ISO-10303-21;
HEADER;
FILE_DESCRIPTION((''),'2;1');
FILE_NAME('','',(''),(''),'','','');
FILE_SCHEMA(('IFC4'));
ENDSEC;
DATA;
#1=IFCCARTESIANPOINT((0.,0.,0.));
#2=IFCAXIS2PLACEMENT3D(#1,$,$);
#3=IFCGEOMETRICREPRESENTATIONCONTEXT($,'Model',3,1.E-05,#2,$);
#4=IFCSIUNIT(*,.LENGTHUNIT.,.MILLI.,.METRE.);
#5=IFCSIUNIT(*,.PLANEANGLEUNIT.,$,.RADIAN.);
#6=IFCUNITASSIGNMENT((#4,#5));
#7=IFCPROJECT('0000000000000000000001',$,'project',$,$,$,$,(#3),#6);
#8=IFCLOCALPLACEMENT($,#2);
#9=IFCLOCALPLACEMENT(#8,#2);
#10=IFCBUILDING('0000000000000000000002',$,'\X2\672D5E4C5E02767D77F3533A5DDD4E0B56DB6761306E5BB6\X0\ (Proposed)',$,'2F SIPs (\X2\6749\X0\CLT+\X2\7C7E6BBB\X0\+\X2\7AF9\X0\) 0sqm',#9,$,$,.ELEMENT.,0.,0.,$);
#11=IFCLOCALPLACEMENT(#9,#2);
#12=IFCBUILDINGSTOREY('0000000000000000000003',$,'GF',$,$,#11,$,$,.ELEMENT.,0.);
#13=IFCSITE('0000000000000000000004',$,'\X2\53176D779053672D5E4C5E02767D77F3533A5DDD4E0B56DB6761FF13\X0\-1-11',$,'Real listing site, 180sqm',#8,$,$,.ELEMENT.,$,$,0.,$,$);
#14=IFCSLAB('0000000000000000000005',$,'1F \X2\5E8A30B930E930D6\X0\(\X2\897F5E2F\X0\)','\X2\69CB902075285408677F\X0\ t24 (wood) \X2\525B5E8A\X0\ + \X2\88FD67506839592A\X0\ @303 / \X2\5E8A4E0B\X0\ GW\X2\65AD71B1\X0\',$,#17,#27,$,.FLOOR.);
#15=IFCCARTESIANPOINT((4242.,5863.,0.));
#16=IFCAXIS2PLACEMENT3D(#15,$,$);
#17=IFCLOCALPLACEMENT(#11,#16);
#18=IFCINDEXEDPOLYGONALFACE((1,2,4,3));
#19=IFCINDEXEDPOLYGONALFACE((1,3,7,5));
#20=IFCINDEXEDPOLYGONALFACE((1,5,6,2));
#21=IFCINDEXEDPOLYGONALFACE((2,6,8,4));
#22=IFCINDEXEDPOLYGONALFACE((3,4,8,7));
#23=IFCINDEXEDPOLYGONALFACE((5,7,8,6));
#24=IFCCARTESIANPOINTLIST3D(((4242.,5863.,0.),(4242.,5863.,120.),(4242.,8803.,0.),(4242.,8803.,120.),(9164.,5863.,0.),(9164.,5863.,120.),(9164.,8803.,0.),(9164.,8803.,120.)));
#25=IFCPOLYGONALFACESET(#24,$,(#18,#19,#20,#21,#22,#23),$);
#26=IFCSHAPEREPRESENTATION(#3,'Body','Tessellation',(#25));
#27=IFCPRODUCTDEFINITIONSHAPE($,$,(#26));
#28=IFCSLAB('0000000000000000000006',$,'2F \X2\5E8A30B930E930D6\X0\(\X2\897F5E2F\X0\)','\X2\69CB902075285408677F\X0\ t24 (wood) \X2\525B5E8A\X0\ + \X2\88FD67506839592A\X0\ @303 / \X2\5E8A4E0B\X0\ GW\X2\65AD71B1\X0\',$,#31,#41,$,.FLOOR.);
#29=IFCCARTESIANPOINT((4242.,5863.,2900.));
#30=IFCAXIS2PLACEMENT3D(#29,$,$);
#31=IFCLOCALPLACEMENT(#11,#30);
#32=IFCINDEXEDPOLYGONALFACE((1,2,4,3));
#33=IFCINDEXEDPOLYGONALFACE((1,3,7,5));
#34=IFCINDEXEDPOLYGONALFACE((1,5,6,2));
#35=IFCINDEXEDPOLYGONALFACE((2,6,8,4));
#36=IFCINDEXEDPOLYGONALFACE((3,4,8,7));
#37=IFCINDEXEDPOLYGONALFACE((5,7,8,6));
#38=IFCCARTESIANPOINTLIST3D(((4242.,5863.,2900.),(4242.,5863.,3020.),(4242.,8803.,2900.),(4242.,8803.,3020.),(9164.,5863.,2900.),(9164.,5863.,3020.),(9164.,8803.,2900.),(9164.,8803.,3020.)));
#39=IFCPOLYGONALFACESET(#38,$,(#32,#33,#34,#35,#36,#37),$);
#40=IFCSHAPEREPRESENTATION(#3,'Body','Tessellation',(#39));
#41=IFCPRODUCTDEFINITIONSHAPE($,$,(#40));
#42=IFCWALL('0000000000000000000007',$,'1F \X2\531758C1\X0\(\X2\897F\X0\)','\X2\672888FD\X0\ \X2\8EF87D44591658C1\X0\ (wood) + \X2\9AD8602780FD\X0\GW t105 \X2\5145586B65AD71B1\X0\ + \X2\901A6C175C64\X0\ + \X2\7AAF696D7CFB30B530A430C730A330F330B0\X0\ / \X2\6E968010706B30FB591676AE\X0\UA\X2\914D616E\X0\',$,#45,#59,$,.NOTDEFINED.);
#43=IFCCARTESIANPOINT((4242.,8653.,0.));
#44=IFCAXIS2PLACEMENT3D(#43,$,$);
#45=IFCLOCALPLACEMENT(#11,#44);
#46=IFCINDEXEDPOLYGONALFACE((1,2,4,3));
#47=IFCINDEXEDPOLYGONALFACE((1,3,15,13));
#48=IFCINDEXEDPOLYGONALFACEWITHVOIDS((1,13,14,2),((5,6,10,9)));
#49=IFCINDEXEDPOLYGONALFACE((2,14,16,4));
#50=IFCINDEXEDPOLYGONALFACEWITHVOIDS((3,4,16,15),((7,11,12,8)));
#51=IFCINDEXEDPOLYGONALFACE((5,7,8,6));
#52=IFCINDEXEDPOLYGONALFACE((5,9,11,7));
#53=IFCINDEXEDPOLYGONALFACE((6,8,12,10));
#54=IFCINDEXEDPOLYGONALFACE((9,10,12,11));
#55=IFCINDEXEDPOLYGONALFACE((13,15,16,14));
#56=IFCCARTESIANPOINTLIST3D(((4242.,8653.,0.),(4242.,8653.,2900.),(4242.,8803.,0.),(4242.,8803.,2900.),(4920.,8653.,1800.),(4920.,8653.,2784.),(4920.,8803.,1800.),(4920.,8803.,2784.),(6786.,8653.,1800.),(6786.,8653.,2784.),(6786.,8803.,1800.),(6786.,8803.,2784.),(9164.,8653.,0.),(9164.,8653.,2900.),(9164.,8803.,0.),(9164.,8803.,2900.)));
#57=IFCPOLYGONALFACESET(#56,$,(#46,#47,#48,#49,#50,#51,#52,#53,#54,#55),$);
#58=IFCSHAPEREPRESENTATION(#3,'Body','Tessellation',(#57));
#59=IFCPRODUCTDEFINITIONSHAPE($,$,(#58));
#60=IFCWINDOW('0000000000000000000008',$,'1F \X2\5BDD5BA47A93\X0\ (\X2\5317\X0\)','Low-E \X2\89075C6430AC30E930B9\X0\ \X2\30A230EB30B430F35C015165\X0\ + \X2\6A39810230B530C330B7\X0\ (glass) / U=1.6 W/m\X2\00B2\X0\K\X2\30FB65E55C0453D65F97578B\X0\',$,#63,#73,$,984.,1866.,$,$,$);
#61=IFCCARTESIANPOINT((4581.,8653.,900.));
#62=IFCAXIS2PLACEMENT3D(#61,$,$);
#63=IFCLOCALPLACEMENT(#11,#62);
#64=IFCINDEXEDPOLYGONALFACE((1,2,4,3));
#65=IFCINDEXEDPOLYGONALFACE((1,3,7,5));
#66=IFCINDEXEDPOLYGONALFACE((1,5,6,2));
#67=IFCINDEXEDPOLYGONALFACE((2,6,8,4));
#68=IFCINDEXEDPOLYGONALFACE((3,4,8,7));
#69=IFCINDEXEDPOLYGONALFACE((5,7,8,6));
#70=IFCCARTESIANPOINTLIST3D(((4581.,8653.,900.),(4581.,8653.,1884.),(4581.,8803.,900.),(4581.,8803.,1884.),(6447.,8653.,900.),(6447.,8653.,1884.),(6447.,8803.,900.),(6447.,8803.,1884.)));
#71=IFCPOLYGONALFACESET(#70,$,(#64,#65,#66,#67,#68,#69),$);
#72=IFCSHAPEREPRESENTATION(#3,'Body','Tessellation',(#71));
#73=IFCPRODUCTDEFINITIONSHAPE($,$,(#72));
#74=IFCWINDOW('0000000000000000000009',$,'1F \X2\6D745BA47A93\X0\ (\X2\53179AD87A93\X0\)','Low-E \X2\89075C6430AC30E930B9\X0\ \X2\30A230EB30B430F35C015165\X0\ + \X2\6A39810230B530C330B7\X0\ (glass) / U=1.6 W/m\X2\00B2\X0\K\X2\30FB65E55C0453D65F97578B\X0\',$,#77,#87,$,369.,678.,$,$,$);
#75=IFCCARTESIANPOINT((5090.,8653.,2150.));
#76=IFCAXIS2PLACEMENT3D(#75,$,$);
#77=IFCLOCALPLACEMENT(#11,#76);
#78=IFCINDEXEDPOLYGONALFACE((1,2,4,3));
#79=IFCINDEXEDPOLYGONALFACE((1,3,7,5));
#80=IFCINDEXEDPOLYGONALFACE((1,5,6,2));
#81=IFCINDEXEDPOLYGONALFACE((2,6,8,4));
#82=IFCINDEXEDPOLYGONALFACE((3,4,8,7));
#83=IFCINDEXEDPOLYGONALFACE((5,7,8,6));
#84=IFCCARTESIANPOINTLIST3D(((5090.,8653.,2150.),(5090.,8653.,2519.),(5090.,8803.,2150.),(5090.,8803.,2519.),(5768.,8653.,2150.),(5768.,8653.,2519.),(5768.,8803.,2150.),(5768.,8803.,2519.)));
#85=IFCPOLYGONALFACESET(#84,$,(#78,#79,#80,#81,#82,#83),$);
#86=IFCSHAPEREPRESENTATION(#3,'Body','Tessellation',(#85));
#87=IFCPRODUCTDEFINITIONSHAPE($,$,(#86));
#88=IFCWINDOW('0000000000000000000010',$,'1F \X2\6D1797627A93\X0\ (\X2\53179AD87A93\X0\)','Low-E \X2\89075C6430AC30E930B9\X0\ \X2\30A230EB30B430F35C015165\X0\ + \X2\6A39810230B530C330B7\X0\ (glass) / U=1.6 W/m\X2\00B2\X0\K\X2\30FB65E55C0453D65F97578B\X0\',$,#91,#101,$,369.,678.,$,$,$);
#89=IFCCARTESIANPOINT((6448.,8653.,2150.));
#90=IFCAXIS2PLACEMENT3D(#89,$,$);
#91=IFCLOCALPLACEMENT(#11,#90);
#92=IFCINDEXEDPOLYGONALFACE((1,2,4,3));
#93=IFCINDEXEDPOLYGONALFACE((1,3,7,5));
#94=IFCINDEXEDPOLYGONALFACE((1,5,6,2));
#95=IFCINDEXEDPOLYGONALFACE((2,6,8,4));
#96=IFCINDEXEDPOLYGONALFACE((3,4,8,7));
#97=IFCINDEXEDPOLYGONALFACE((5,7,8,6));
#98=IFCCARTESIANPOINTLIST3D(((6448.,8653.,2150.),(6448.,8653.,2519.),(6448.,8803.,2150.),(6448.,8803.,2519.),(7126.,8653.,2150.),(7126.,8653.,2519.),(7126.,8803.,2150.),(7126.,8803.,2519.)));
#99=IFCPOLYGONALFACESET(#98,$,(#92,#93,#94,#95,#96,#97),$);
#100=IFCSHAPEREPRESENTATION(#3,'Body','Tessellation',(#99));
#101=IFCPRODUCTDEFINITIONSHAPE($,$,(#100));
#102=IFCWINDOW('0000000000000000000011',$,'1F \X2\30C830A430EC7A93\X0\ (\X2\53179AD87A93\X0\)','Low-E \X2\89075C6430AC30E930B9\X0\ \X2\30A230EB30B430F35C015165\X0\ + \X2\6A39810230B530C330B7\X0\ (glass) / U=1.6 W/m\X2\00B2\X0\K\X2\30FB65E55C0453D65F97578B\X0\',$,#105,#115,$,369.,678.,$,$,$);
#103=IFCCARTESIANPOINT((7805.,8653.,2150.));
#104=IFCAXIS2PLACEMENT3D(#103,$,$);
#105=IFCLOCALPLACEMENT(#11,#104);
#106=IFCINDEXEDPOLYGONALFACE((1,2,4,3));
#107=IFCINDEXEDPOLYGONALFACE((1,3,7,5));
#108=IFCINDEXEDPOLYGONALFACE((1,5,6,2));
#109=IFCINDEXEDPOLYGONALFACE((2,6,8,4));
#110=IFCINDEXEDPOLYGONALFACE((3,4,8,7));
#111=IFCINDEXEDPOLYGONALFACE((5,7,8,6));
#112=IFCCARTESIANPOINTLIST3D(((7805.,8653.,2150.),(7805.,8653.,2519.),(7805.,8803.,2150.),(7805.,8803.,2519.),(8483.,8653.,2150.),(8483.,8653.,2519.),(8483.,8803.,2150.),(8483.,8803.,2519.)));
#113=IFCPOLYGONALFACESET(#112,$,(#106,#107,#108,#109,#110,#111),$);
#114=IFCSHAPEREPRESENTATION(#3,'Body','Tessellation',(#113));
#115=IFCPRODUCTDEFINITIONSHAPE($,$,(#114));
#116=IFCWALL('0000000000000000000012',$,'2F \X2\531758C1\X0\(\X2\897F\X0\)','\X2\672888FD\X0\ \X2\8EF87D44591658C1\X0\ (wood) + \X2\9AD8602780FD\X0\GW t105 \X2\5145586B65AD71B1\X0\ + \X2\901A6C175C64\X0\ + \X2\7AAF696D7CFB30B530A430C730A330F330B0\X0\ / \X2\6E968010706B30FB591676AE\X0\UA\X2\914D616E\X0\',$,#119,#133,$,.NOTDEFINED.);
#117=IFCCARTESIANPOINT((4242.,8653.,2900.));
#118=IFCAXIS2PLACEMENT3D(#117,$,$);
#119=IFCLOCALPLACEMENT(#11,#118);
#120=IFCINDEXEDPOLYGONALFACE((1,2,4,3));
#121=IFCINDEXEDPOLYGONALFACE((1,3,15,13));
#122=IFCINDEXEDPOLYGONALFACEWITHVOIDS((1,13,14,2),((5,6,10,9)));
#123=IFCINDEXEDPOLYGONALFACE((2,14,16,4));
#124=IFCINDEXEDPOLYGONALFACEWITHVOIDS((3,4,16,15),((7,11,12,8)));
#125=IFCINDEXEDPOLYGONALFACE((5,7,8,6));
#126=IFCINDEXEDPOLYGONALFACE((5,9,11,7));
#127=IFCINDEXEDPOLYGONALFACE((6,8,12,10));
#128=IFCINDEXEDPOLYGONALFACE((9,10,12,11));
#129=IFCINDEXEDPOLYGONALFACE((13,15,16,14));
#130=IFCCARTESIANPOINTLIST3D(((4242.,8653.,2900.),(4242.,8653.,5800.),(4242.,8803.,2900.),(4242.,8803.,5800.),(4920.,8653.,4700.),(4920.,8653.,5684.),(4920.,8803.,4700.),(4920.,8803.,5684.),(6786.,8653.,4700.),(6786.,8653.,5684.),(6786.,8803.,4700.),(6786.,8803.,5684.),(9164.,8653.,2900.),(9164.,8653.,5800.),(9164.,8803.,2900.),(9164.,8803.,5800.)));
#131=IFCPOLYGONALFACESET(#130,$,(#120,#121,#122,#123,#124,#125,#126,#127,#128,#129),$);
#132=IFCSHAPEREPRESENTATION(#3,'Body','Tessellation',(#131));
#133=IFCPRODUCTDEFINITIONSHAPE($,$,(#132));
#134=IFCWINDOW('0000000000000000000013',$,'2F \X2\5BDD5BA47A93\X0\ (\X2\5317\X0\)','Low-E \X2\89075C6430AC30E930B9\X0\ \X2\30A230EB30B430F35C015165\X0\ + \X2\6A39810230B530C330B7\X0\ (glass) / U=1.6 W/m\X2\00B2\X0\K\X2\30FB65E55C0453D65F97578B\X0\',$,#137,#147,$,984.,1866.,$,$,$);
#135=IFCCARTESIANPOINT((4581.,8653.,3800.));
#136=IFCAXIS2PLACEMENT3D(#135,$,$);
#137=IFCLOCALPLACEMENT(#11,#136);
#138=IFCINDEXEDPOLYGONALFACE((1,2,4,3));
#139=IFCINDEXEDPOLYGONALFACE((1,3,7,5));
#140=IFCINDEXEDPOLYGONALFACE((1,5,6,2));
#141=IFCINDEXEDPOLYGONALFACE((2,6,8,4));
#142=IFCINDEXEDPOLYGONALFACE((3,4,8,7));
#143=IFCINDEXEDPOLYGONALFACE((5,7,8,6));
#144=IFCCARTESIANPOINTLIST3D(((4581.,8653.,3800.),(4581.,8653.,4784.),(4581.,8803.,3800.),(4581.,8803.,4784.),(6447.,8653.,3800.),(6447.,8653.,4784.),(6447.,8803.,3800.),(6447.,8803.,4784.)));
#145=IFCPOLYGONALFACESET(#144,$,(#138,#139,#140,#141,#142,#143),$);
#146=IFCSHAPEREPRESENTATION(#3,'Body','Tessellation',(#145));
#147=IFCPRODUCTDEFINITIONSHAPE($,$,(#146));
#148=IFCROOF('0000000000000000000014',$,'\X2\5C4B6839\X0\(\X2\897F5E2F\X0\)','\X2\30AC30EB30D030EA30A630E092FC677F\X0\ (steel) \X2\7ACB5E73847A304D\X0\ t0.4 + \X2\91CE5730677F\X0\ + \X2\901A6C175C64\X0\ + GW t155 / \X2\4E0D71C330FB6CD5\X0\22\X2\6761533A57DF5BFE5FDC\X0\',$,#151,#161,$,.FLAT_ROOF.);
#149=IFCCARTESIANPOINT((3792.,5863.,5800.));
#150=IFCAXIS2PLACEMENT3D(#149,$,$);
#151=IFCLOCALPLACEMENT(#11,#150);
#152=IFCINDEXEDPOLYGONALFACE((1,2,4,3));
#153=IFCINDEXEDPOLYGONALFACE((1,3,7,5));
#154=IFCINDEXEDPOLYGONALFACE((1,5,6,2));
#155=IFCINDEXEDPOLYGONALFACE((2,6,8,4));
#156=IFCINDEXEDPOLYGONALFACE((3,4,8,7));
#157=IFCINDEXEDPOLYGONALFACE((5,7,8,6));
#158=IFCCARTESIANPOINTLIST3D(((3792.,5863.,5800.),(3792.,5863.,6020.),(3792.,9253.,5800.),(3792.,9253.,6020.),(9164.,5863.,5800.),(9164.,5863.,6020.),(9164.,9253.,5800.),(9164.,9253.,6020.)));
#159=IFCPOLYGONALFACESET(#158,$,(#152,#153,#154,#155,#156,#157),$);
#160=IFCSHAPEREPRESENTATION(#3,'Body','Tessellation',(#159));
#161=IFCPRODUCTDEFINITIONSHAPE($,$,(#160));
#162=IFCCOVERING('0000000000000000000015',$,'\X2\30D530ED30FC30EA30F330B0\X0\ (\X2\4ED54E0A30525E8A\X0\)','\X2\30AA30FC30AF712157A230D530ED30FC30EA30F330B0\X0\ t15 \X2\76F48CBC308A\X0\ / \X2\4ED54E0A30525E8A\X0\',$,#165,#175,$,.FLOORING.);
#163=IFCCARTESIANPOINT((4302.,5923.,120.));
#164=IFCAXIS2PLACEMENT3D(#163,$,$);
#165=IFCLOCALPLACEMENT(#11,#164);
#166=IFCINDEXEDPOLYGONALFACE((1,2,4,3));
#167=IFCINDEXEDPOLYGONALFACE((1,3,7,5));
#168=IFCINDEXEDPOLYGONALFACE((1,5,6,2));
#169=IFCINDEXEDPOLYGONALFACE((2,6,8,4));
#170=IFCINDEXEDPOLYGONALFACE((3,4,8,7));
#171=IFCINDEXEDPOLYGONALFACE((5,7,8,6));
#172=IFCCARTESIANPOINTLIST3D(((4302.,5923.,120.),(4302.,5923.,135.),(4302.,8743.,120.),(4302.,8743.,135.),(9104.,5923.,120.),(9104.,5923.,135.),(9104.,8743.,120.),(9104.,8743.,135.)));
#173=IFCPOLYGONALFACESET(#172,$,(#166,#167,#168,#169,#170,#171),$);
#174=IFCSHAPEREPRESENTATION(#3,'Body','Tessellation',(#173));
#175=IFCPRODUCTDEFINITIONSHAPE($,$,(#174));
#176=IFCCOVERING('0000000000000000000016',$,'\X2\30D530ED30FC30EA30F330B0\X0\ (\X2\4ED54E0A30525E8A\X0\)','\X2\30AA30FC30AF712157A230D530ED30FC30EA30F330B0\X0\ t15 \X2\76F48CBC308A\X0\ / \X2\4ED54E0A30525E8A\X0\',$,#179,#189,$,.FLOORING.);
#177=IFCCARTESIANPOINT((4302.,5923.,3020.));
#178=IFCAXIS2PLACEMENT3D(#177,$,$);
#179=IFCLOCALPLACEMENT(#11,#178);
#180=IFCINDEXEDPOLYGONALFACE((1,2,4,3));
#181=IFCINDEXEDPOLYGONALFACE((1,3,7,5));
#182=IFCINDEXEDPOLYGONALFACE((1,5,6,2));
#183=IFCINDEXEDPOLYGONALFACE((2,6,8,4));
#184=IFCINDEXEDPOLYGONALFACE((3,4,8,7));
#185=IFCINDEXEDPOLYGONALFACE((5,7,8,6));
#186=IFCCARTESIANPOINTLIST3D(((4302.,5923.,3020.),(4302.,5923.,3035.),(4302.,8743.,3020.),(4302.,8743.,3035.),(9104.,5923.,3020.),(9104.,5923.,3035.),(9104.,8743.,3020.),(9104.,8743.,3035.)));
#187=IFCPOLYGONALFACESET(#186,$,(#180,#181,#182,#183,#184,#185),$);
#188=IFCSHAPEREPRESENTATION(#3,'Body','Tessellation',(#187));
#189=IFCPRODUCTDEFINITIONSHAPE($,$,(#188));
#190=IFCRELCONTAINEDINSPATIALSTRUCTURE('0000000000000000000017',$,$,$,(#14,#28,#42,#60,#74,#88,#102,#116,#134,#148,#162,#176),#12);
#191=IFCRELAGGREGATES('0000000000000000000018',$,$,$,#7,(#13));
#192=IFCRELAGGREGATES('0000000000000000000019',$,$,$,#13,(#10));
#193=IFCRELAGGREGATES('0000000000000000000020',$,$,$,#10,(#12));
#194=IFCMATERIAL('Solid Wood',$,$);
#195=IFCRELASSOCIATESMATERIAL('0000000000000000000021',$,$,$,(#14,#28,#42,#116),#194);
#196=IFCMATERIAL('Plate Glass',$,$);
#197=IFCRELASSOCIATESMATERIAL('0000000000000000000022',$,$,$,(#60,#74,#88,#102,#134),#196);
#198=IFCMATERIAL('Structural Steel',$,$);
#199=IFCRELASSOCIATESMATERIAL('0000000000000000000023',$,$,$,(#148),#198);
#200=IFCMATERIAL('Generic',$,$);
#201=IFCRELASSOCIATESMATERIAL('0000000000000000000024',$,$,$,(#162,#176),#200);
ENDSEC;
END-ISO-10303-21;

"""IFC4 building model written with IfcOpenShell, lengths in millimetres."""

from ifc_helpers import new_model, si_unit, frame, frame_2d, origin, place, context, project, spatial, rectangle, extrude, material, element, fill, save


model = new_model("IFC4")

# Units and contexts
model_context = context("Model", 3, precision=1e-05, world=origin())
ifc_project = project(units=[si_unit("LENGTHUNIT", "METRE", prefix="MILLI"), si_unit("PLANEANGLEUNIT", "RADIAN")], contexts=[model_context])

# Site, building, storey
site_placement = place(None, origin())
site = spatial("IfcSite", under=ifc_project, at=site_placement, Name="北海道札幌市白石区川下四条３-1-11", ObjectType="Real listing site, 180sqm", CompositionType="ELEMENT", RefElevation=0.0)
building_placement = place(site_placement, origin())
building = spatial("IfcBuilding", under=site, at=building_placement, Name="札幌市白石区川下四条の家 (Proposed)", ObjectType="2F SIPs (杉CLT+籾殻+竹) 0sqm", CompositionType="ELEMENT", ElevationOfRefHeight=0.0, ElevationOfTerrain=0.0)
storey_placement = place(building_placement, origin())
storey = spatial("IfcBuildingStorey", under=building, at=storey_placement, Name="GF", CompositionType="ELEMENT", Elevation=0.0)

# Slabs
ifc_material_1 = material(Name="Solid Wood")
slab_1_placement = place(storey_placement, frame((4242.0, 5863.0, 0.0)))
element("IfcSlab", 1, at=slab_1_placement, inside=storey, material=ifc_material_1, Name="1F 床スラブ(西帯)", Description="構造用合板 t24 (wood) 剛床 + 製材根太 @303 / 床下 GW断熱", PredefinedType="FLOOR", context=model_context, shape_type="SweptSolid", body=[
    extrude(rectangle(XDim=4922.0, YDim=2940.0, at=frame_2d((2461.0, 1470.0))), frame((4242.0, 5863.0, 0.0)), (0.0, 0.0, 1.0), 120.0),
])
slab_2_placement = place(storey_placement, frame((4242.0, 5863.0, 2900.0)))
element("IfcSlab", 2, at=slab_2_placement, inside=storey, material=ifc_material_1, Name="2F 床スラブ(西帯)", Description="構造用合板 t24 (wood) 剛床 + 製材根太 @303 / 床下 GW断熱", PredefinedType="FLOOR", context=model_context, shape_type="SweptSolid", body=[
    extrude(rectangle(XDim=4922.0, YDim=2940.0, at=frame_2d((2461.0, 1470.0))), frame((4242.0, 5863.0, 2900.0)), (0.0, 0.0, 1.0), 120.0),
])

# Wall, openings, windows
wall_1_placement = place(storey_placement, frame((4242.0, 8653.0, 0.0)))
wall_1 = element("IfcWall", 3, at=wall_1_placement, inside=storey, material=ifc_material_1, Name="1F 北壁(西)", Description="木製 軸組外壁 (wood) + 高性能GW t105 充填断熱 + 通気層 + 窯業系サイディング / 準耐火・外皮UA配慮", PredefinedType="NOTDEFINED", context=model_context, shape_type="SweptSolid", body=[
    extrude(rectangle(XDim=4922.0, YDim=150.0, at=frame_2d((2461.0, 75.0))), frame((4242.0, 8653.0, 0.0)), (0.0, 0.0, 1.0), 2900.0),
])
opening_1_placement = place(storey_placement, frame((4581.0, 8653.0, 900.0)))
opening_1 = element("IfcOpeningElement", 4, at=opening_1_placement, cuts=wall_1, PredefinedType="NOTDEFINED", context=model_context, shape_type="SweptSolid", body=[
    extrude(rectangle(XDim=1866.0, YDim=150.0, at=frame_2d((933.0, 75.0))), frame((4581.0, 8653.0, 900.0)), (0.0, 0.0, 1.0), 984.0),
])
opening_2_placement = place(storey_placement, frame((5090.0, 8653.0, 2150.0)))
opening_2 = element("IfcOpeningElement", 5, at=opening_2_placement, cuts=wall_1, PredefinedType="NOTDEFINED", context=model_context, shape_type="SweptSolid", body=[
    extrude(rectangle(XDim=678.0, YDim=150.0, at=frame_2d((339.0, 75.0))), frame((5090.0, 8653.0, 2150.0)), (0.0, 0.0, 1.0), 369.0),
])
opening_3_placement = place(storey_placement, frame((6448.0, 8653.0, 2150.0)))
opening_3 = element("IfcOpeningElement", 6, at=opening_3_placement, cuts=wall_1, PredefinedType="NOTDEFINED", context=model_context, shape_type="SweptSolid", body=[
    extrude(rectangle(XDim=678.0, YDim=150.0, at=frame_2d((339.0, 75.0))), frame((6448.0, 8653.0, 2150.0)), (0.0, 0.0, 1.0), 369.0),
])
opening_4_placement = place(storey_placement, frame((7805.0, 8653.0, 2150.0)))
opening_4 = element("IfcOpeningElement", 7, at=opening_4_placement, cuts=wall_1, PredefinedType="NOTDEFINED", context=model_context, shape_type="SweptSolid", body=[
    extrude(rectangle(XDim=678.0, YDim=150.0, at=frame_2d((339.0, 75.0))), frame((7805.0, 8653.0, 2150.0)), (0.0, 0.0, 1.0), 369.0),
])
ifc_material_2 = material(Name="Plate Glass")
window_1_placement = place(storey_placement, frame((4581.0, 8653.0, 900.0)))
window_1 = element("IfcWindow", 8, at=window_1_placement, inside=storey, material=ifc_material_2, Name="1F 寝室窓 (北)", Description="Low-E 複層ガラス アルゴン封入 + 樹脂サッシ (glass) / U=1.6 W/m²K・日射取得型", OverallHeight=984.0, OverallWidth=1866.0, context=model_context, shape_type="SweptSolid", body=[
    extrude(rectangle(XDim=1866.0, YDim=150.0, at=frame_2d((933.0, 75.0))), frame((4581.0, 8653.0, 900.0)), (0.0, 0.0, 1.0), 984.0),
])
fill(opening_1, window_1)
window_2_placement = place(storey_placement, frame((5090.0, 8653.0, 2150.0)))
window_2 = element("IfcWindow", 9, at=window_2_placement, inside=storey, material=ifc_material_2, Name="1F 浴室窓 (北高窓)", Description="Low-E 複層ガラス アルゴン封入 + 樹脂サッシ (glass) / U=1.6 W/m²K・日射取得型", OverallHeight=369.0, OverallWidth=678.0, context=model_context, shape_type="SweptSolid", body=[
    extrude(rectangle(XDim=678.0, YDim=150.0, at=frame_2d((339.0, 75.0))), frame((5090.0, 8653.0, 2150.0)), (0.0, 0.0, 1.0), 369.0),
])
fill(opening_2, window_2)
window_3_placement = place(storey_placement, frame((6448.0, 8653.0, 2150.0)))
window_3 = element("IfcWindow", 10, at=window_3_placement, inside=storey, material=ifc_material_2, Name="1F 洗面窓 (北高窓)", Description="Low-E 複層ガラス アルゴン封入 + 樹脂サッシ (glass) / U=1.6 W/m²K・日射取得型", OverallHeight=369.0, OverallWidth=678.0, context=model_context, shape_type="SweptSolid", body=[
    extrude(rectangle(XDim=678.0, YDim=150.0, at=frame_2d((339.0, 75.0))), frame((6448.0, 8653.0, 2150.0)), (0.0, 0.0, 1.0), 369.0),
])
fill(opening_3, window_3)
window_4_placement = place(storey_placement, frame((7805.0, 8653.0, 2150.0)))
window_4 = element("IfcWindow", 11, at=window_4_placement, inside=storey, material=ifc_material_2, Name="1F トイレ窓 (北高窓)", Description="Low-E 複層ガラス アルゴン封入 + 樹脂サッシ (glass) / U=1.6 W/m²K・日射取得型", OverallHeight=369.0, OverallWidth=678.0, context=model_context, shape_type="SweptSolid", body=[
    extrude(rectangle(XDim=678.0, YDim=150.0, at=frame_2d((339.0, 75.0))), frame((7805.0, 8653.0, 2150.0)), (0.0, 0.0, 1.0), 369.0),
])
fill(opening_4, window_4)

# Wall, opening, window
wall_2_placement = place(storey_placement, frame((4242.0, 8653.0, 2900.0)))
wall_2 = element("IfcWall", 12, at=wall_2_placement, inside=storey, material=ifc_material_1, Name="2F 北壁(西)", Description="木製 軸組外壁 (wood) + 高性能GW t105 充填断熱 + 通気層 + 窯業系サイディング / 準耐火・外皮UA配慮", PredefinedType="NOTDEFINED", context=model_context, shape_type="SweptSolid", body=[
    extrude(rectangle(XDim=4922.0, YDim=150.0, at=frame_2d((2461.0, 75.0))), frame((4242.0, 8653.0, 2900.0)), (0.0, 0.0, 1.0), 2900.0),
])
opening_5_placement = place(storey_placement, frame((4581.0, 8653.0, 3800.0)))
opening_5 = element("IfcOpeningElement", 13, at=opening_5_placement, cuts=wall_2, PredefinedType="NOTDEFINED", context=model_context, shape_type="SweptSolid", body=[
    extrude(rectangle(XDim=1866.0, YDim=150.0, at=frame_2d((933.0, 75.0))), frame((4581.0, 8653.0, 3800.0)), (0.0, 0.0, 1.0), 984.0),
])
window_5_placement = place(storey_placement, frame((4581.0, 8653.0, 3800.0)))
window_5 = element("IfcWindow", 14, at=window_5_placement, inside=storey, material=ifc_material_2, Name="2F 寝室窓 (北)", Description="Low-E 複層ガラス アルゴン封入 + 樹脂サッシ (glass) / U=1.6 W/m²K・日射取得型", OverallHeight=984.0, OverallWidth=1866.0, context=model_context, shape_type="SweptSolid", body=[
    extrude(rectangle(XDim=1866.0, YDim=150.0, at=frame_2d((933.0, 75.0))), frame((4581.0, 8653.0, 3800.0)), (0.0, 0.0, 1.0), 984.0),
])
fill(opening_5, window_5)

# Roof
ifc_material_3 = material(Name="Structural Steel")
for number, where, name in (
    (15, (3792.0, 5863.0, 5800.0), "屋根(西帯)"),
):
    element("IfcRoof", number, at=place(storey_placement, frame(where)), inside=storey, material=ifc_material_3, Name=name, Description="ガルバリウム鋼板 (steel) 立平葺き t0.4 + 野地板 + 通気層 + GW t155 / 不燃・法22条区域対応", PredefinedType="FLAT_ROOF", context=model_context, shape_type="SweptSolid", body=[
        extrude(rectangle(XDim=5372.0, YDim=3390.0, at=frame_2d((2686.0, 1695.0))), frame((3792.0, 5863.0, 5800.0)), (0.0, 0.0, 1.0), 220.0),
    ])

# Coverings
ifc_material_4 = material(Name="Generic")
covering_1_placement = place(storey_placement, frame((4302.0, 5923.0, 120.0)))
element("IfcCovering", 16, at=covering_1_placement, inside=storey, material=ifc_material_4, Name="フローリング (仕上げ床)", Description="オーク無垢フローリング t15 直貼り / 仕上げ床", PredefinedType="FLOORING", context=model_context, shape_type="SweptSolid", body=[
    extrude(rectangle(XDim=4802.0, YDim=2820.0, at=frame_2d((2401.0, 1410.0))), frame((4302.0, 5923.0, 120.0)), (0.0, 0.0, 1.0), 15.0),
])
covering_2_placement = place(storey_placement, frame((4302.0, 5923.0, 3020.0)))
element("IfcCovering", 17, at=covering_2_placement, inside=storey, material=ifc_material_4, Name="フローリング (仕上げ床)", Description="オーク無垢フローリング t15 直貼り / 仕上げ床", PredefinedType="FLOORING", context=model_context, shape_type="SweptSolid", body=[
    extrude(rectangle(XDim=4802.0, YDim=2820.0, at=frame_2d((2401.0, 1410.0))), frame((4302.0, 5923.0, 3020.0)), (0.0, 0.0, 1.0), 15.0),
])

save(model, "model.ifc")
